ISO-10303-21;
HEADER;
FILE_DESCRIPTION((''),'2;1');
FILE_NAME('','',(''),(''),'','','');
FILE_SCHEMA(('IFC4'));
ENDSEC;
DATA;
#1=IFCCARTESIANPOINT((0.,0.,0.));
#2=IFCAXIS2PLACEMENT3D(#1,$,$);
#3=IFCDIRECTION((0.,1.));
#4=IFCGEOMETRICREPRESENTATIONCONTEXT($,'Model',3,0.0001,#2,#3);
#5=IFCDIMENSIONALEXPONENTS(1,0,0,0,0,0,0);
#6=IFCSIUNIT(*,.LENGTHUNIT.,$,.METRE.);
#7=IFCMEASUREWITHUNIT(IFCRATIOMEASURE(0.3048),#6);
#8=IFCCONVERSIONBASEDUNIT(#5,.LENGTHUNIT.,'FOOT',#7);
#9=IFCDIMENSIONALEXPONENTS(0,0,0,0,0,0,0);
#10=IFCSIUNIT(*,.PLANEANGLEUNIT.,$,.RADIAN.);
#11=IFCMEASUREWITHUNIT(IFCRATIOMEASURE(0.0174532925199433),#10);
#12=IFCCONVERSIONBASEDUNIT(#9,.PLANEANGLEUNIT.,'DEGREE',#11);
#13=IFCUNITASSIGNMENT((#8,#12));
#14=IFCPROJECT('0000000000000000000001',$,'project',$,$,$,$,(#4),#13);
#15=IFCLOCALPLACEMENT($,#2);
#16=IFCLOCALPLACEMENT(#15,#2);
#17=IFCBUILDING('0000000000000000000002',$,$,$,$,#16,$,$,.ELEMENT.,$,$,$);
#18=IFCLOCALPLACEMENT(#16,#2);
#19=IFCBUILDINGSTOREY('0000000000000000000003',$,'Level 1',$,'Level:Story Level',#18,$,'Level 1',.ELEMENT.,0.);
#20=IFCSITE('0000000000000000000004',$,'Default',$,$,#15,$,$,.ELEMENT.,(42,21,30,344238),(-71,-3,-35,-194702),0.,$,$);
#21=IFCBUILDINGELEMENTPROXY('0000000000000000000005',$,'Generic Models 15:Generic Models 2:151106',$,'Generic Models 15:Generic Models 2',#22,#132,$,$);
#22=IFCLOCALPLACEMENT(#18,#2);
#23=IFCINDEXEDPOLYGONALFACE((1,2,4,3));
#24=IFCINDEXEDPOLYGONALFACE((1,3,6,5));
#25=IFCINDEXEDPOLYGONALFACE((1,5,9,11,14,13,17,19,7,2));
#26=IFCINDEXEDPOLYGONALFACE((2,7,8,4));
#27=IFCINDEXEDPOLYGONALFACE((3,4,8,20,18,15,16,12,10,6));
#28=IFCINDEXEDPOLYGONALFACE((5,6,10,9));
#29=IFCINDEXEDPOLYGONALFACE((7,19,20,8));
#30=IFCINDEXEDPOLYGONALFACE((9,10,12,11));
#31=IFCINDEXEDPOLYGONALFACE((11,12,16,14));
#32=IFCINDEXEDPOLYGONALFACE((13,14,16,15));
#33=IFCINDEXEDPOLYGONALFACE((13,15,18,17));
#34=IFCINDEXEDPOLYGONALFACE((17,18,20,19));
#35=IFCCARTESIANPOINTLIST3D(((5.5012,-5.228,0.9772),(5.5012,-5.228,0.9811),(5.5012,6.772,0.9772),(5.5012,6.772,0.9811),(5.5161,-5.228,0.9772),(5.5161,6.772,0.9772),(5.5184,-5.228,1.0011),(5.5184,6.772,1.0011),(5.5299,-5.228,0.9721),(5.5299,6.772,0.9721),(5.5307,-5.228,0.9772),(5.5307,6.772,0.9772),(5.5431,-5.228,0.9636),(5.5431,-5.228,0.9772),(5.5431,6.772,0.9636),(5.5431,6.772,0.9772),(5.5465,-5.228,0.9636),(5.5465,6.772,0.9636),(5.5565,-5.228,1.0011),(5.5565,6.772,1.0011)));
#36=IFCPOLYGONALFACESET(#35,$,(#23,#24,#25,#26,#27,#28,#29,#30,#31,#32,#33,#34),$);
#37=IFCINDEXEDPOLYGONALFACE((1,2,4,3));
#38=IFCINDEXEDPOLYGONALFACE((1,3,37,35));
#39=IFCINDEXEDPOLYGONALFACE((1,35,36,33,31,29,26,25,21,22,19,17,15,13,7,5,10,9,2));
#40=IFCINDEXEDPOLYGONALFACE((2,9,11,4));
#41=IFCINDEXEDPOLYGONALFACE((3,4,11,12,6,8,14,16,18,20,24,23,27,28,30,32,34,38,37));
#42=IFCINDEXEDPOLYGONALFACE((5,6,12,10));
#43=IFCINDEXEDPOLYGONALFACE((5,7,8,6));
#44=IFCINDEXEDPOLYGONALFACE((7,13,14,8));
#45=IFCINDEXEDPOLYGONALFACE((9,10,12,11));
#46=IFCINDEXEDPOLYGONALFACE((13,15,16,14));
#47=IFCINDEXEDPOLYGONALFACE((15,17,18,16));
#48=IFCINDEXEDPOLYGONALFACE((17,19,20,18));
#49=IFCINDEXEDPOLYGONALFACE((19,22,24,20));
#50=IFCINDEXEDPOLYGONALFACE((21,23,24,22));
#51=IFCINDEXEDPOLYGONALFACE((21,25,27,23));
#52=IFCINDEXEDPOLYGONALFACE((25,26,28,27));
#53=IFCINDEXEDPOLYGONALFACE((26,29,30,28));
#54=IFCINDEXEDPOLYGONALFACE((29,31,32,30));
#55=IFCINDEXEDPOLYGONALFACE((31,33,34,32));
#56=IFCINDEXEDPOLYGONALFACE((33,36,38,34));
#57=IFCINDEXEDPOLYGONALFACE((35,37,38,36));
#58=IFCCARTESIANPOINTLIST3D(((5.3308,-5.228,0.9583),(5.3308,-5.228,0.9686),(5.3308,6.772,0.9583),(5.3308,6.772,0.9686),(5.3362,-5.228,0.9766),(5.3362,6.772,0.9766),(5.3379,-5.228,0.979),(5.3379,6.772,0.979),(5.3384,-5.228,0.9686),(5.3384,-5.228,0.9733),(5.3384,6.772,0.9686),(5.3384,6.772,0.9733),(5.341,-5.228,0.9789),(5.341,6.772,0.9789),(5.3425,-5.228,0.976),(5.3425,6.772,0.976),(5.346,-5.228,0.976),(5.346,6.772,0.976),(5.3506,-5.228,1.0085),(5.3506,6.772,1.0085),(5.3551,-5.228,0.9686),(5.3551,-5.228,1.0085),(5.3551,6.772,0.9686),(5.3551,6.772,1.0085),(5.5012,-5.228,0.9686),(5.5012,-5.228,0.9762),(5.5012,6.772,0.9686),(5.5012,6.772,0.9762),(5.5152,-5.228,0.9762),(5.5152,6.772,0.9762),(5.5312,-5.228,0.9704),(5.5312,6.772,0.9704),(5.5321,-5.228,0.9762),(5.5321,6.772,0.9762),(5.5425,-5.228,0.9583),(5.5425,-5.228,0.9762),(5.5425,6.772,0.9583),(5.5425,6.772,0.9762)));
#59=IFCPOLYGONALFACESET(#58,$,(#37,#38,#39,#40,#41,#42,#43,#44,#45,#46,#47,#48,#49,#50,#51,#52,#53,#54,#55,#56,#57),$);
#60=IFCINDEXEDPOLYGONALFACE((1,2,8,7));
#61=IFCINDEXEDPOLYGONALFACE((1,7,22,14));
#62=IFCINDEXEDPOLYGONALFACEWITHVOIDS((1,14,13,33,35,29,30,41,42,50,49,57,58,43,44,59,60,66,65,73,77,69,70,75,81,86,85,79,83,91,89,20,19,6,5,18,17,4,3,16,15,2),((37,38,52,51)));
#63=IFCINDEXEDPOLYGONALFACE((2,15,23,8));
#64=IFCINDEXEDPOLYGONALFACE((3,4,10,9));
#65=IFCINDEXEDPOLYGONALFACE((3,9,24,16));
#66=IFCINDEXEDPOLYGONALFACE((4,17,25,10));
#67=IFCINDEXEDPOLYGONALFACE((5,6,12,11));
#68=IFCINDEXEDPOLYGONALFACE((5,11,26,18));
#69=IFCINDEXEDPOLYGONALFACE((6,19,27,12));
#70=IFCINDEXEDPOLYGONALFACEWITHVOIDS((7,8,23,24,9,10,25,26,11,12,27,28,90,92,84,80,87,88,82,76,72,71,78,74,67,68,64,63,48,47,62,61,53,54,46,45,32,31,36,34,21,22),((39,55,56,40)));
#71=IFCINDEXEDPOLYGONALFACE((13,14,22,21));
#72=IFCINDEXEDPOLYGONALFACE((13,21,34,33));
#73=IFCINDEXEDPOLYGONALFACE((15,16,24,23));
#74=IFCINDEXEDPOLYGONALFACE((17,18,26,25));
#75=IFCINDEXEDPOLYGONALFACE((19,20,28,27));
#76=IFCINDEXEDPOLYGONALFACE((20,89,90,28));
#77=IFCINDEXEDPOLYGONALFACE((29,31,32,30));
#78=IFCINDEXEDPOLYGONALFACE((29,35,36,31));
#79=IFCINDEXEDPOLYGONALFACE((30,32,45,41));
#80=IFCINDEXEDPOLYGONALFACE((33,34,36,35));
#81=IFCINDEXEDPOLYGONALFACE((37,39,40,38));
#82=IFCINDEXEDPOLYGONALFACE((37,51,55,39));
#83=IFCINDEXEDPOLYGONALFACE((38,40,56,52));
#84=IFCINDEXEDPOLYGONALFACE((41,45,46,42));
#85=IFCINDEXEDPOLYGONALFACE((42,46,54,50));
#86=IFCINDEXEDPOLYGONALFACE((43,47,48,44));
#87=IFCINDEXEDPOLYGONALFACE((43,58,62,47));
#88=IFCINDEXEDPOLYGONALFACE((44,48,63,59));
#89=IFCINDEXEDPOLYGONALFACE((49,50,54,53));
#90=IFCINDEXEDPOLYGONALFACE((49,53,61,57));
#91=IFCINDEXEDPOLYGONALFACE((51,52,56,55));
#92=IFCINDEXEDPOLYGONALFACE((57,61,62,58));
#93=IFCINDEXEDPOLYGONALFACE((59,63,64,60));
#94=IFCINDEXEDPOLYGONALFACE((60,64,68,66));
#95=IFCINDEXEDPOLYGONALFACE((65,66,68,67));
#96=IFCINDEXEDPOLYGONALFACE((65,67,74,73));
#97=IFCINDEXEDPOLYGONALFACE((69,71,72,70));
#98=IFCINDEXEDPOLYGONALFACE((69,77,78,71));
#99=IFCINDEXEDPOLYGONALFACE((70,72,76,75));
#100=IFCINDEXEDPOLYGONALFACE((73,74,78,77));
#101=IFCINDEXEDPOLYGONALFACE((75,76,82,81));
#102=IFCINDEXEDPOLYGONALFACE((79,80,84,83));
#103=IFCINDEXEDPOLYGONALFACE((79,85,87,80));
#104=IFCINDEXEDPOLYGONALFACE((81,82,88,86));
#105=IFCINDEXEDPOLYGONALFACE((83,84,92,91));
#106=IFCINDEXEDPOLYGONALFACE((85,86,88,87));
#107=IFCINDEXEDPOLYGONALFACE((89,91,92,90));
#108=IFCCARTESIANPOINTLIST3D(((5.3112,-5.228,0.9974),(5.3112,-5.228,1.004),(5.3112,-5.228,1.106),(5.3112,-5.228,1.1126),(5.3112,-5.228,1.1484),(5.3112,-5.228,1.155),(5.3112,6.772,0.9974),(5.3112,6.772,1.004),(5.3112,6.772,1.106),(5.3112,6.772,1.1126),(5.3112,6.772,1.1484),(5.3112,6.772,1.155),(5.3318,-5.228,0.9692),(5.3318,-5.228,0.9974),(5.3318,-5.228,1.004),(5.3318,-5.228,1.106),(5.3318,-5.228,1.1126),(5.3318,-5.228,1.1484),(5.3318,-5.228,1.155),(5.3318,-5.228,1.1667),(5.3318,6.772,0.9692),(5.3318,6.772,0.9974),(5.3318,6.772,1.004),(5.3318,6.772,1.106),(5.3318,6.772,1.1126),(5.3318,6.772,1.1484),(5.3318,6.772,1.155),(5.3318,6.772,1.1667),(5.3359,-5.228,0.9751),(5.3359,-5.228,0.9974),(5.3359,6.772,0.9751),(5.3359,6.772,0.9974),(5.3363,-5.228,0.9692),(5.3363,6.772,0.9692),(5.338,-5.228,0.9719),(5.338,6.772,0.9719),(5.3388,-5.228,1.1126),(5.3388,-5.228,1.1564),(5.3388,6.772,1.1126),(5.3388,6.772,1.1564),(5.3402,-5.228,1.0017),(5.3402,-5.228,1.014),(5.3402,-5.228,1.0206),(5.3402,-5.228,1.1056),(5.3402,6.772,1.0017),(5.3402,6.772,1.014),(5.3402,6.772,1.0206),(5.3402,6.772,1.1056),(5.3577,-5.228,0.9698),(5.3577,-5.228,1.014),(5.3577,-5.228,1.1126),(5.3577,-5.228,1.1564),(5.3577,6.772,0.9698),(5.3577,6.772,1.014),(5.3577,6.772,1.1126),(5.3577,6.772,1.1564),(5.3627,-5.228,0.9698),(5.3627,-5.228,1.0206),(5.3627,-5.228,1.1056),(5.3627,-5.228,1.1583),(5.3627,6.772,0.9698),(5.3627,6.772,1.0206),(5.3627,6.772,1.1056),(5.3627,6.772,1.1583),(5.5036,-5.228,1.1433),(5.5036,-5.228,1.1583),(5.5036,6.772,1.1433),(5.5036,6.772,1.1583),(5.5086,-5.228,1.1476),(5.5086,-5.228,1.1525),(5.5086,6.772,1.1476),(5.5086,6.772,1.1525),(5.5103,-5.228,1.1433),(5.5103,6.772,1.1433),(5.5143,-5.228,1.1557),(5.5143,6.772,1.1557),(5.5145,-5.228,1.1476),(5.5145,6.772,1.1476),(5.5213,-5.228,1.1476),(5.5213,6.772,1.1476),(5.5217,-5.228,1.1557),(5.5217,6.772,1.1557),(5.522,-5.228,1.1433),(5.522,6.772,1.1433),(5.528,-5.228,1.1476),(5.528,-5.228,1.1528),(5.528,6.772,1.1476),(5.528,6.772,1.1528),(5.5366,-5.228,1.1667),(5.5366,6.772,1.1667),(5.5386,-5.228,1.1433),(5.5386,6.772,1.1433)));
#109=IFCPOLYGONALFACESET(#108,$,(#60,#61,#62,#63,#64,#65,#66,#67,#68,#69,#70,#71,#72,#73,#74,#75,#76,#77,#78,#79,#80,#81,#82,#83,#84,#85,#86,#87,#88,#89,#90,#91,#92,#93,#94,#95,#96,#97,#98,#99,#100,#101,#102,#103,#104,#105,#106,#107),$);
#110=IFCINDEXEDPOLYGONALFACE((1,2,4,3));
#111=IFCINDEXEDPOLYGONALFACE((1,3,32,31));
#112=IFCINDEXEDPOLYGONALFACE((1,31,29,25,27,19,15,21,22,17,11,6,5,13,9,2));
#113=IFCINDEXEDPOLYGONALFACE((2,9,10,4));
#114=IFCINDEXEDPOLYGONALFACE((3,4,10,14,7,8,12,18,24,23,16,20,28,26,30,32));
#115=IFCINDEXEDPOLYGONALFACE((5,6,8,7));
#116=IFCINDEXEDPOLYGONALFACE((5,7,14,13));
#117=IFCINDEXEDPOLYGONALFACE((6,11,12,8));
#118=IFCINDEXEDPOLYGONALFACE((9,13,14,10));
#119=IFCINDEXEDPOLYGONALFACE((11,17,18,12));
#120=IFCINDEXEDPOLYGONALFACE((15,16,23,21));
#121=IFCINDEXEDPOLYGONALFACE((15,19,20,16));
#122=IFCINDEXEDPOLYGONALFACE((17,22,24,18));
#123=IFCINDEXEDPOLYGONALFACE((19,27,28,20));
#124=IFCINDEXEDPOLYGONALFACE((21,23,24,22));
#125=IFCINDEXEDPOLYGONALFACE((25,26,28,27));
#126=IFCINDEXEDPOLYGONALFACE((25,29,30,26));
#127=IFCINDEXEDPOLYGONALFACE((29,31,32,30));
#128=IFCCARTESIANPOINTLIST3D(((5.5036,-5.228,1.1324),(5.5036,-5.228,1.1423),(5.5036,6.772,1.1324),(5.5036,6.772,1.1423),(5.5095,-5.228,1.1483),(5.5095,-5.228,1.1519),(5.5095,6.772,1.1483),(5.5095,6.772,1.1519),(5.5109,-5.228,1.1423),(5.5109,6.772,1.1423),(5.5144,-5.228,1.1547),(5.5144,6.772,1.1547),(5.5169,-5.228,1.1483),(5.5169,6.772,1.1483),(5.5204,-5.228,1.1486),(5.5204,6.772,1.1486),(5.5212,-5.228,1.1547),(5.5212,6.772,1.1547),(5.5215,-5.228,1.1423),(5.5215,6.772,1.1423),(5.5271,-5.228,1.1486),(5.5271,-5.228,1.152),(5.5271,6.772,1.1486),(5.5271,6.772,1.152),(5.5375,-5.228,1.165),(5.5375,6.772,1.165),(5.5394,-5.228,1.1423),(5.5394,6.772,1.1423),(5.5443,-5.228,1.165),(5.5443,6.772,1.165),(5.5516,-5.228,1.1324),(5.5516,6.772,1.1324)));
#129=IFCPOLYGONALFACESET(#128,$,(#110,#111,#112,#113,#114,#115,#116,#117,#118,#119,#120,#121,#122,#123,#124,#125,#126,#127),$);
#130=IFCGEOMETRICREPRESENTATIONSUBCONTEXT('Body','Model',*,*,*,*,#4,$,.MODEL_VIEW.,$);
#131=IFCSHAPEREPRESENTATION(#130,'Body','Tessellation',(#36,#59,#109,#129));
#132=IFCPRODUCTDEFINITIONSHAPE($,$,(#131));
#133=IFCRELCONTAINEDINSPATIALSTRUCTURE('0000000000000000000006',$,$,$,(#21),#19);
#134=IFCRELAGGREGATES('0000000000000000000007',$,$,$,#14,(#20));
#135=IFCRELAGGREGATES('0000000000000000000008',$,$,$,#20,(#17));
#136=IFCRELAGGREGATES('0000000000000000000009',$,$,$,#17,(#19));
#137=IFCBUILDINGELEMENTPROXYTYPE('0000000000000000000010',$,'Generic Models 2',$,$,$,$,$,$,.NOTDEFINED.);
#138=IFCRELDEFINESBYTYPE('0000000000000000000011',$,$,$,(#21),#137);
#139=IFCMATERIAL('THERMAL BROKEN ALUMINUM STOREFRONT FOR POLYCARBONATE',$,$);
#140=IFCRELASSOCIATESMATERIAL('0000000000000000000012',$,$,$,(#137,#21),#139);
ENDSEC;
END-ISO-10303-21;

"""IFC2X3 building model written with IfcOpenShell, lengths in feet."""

from ifc_helpers import new_model, entity, si_unit, converted_unit, direction, frame, origin, place, context, subcontext, project, spatial, polyline, outline, extrude, source, transform, mapped, material, type_object, type_shapes, element, save


model = new_model("IFC2X3")

# Units and contexts
model_context = context("Model", 3, precision=0.0001, world=origin(), true_north=direction((0.0, 1.0)))
body_context = subcontext(model_context, "Body", "Model", "MODEL_VIEW")
ifc_project = project(units=[converted_unit("LENGTHUNIT", "FOOT", entity("IfcRatioMeasure", 0.3048), si_unit("LENGTHUNIT", "METRE"), dimensions=[1, 0, 0, 0, 0, 0, 0]), converted_unit("PLANEANGLEUNIT", "DEGREE", entity("IfcRatioMeasure", 0.0174532925199433), si_unit("PLANEANGLEUNIT", "RADIAN"), dimensions=[0, 0, 0, 0, 0, 0, 0])], contexts=[model_context])

# Site, building, storey
site_placement = place(None, origin())
site = spatial("IfcSite", under=ifc_project, at=site_placement, Name="Default", CompositionType="ELEMENT", RefLatitude=(42, 21, 30, 344238), RefLongitude=(-71, -3, -35, -194702), RefElevation=0.0)
building_placement = place(site_placement, origin())
building = spatial("IfcBuilding", under=site, at=building_placement, CompositionType="ELEMENT")
storey_placement = place(building_placement, origin())
storey = spatial("IfcBuildingStorey", under=building, at=storey_placement, Name="Level 1", ObjectType="Level:Story Level", LongName="Level 1", CompositionType="ELEMENT", Elevation=0.0)

# Building element proxy
ifc_material = material(Name="THERMAL BROKEN ALUMINUM STOREFRONT FOR POLYCARBONATE")
building_element_proxy_type_1 = type_object("IfcBuildingElementProxyType", Name="Generic Models 2", PredefinedType="NOTDEFINED", material=ifc_material)
shared_shape_1 = source(origin(), body_context, "Body", "SweptSolid", [
    extrude(outline(polyline([(-0.0178, -0.0155), (-0.0144, -0.0155), (-0.0144, -0.002), (-0.0021, -0.002), (-0.0012, -0.007), (0.0126, -0.002), (0.0275, -0.002), (0.0275, 0.002), (0.0102, 0.022), (-0.0278, 0.022), (-0.0178, -0.0155)])), frame((-15.0475, -0.4208, -0.4887), z_axis=(1.0, 0.0, 0.0), x_axis=(0.0, 1.0, 0.0)), (0.0, 0.0, 1.0), 12.0),
    extrude(outline(polyline([(-0.0355, -0.058), (-0.0371, -0.0606), (-0.0358, -0.0632), (-0.0318, -0.063), (-0.0278, -0.0652), (-0.0315, -0.0718), (-0.0224, -0.0768), (0.0802, 0.1083), (0.0645, 0.1169), (0.0595, 0.1079), (0.0642, 0.1042), (0.0513, 0.0931), (0.0445, 0.0809), (0.0512, 0.0772), (-0.0197, -0.0506), (-0.0545, -0.0312), (-0.0567, -0.0352), (-0.0306, -0.055), (-0.0322, -0.058), (-0.0355, -0.058)])), frame((-15.0475, -0.301, -0.4919), z_axis=(-1.0, 0.0, 0.0), x_axis=(0.0, -0.484974, -0.874529)), (0.0, 0.0, -1.0), 12.0),
    extrude(outline(polyline([(-0.107, -0.073), (-0.107, -0.058), (-0.1137, -0.058), (-0.118, -0.0623), (-0.1121, -0.0623), (-0.1121, -0.0672), (-0.1177, -0.0704), (-0.1252, -0.0704), (-0.1315, -0.0675), (-0.1315, -0.0623), (-0.1248, -0.0623), (-0.1255, -0.058), (-0.142, -0.058), (-0.1401, -0.0814), (0.0647, -0.0814), (0.0647, -0.0697), (0.0853, -0.0697), (0.0853, -0.0631), (0.0647, -0.0631), (0.0647, -0.0273), (0.0853, -0.0273), (0.0853, -0.0207), (0.0647, -0.0207), (0.0647, 0.0812), (0.0853, 0.0812), (0.0853, 0.0878), (0.0647, 0.0878), (0.0647, 0.1161), (0.0603, 0.1161), (0.0585, 0.1133), (0.0606, 0.1102), (0.0606, 0.0878), (0.0564, 0.0836), (0.0564, 0.0713), (0.0389, 0.0713), (0.0389, 0.1155), (0.0338, 0.1155), (0.0338, 0.0647), (0.0564, 0.0647), (0.0564, -0.0203), (0.0338, -0.0203), (0.0338, -0.073), (-0.107, -0.073)]), holes=[polyline([(0.0577, -0.0711), (0.0389, -0.0711), (0.0389, -0.0273), (0.0577, -0.0273), (0.0577, -0.0711)])]), frame((-15.0475, -0.2887, -0.3825), z_axis=(-1.0, 0.0, 0.0), x_axis=(0.0, 1.0, 0.0)), (0.0, 0.0, -1.0), 12.0),
    extrude(outline(polyline([(-0.0292, -0.0159), (0.0189, -0.0159), (0.0189, -0.0059), (0.0115, -0.0059), (0.0055, 0.0001), (0.0129, 0.0001), (0.0129, 0.0037), (0.008, 0.0065), (0.0012, 0.0065), (-0.0047, 0.0038), (-0.0047, 0.0004), (0.002, 0.0004), (0.0009, -0.0059), (-0.017, -0.0059), (-0.015, 0.0168), (-0.0219, 0.0168), (-0.0292, -0.0159)])), frame((-15.0475, -0.4146, -0.3196), z_axis=(1.0, 0.0, 0.0), x_axis=(0.0, 1.0, 0.0)), (0.0, 0.0, 1.0), 12.0),
])
type_shapes(building_element_proxy_type_1, [shared_shape_1])
proxy_1_placement = place(storey_placement, frame((5.1078, 9.8195, 1.4678), z_axis=(0.0, 0.0, 1.0), x_axis=(0.0, 1.0, 0.0)))
element("IfcBuildingElementProxy", 1, at=proxy_1_placement, inside=storey, type_object=building_element_proxy_type_1, material=ifc_material, Name="Generic Models 15:Generic Models 2:151106", ObjectType="Generic Models 15:Generic Models 2", context=body_context, shape_type="MappedRepresentation", body=[
    mapped(shared_shape_1, transform((0.0, 0.0, 0.0), scale=1.0)),
])

save(model, "model.ifc")
